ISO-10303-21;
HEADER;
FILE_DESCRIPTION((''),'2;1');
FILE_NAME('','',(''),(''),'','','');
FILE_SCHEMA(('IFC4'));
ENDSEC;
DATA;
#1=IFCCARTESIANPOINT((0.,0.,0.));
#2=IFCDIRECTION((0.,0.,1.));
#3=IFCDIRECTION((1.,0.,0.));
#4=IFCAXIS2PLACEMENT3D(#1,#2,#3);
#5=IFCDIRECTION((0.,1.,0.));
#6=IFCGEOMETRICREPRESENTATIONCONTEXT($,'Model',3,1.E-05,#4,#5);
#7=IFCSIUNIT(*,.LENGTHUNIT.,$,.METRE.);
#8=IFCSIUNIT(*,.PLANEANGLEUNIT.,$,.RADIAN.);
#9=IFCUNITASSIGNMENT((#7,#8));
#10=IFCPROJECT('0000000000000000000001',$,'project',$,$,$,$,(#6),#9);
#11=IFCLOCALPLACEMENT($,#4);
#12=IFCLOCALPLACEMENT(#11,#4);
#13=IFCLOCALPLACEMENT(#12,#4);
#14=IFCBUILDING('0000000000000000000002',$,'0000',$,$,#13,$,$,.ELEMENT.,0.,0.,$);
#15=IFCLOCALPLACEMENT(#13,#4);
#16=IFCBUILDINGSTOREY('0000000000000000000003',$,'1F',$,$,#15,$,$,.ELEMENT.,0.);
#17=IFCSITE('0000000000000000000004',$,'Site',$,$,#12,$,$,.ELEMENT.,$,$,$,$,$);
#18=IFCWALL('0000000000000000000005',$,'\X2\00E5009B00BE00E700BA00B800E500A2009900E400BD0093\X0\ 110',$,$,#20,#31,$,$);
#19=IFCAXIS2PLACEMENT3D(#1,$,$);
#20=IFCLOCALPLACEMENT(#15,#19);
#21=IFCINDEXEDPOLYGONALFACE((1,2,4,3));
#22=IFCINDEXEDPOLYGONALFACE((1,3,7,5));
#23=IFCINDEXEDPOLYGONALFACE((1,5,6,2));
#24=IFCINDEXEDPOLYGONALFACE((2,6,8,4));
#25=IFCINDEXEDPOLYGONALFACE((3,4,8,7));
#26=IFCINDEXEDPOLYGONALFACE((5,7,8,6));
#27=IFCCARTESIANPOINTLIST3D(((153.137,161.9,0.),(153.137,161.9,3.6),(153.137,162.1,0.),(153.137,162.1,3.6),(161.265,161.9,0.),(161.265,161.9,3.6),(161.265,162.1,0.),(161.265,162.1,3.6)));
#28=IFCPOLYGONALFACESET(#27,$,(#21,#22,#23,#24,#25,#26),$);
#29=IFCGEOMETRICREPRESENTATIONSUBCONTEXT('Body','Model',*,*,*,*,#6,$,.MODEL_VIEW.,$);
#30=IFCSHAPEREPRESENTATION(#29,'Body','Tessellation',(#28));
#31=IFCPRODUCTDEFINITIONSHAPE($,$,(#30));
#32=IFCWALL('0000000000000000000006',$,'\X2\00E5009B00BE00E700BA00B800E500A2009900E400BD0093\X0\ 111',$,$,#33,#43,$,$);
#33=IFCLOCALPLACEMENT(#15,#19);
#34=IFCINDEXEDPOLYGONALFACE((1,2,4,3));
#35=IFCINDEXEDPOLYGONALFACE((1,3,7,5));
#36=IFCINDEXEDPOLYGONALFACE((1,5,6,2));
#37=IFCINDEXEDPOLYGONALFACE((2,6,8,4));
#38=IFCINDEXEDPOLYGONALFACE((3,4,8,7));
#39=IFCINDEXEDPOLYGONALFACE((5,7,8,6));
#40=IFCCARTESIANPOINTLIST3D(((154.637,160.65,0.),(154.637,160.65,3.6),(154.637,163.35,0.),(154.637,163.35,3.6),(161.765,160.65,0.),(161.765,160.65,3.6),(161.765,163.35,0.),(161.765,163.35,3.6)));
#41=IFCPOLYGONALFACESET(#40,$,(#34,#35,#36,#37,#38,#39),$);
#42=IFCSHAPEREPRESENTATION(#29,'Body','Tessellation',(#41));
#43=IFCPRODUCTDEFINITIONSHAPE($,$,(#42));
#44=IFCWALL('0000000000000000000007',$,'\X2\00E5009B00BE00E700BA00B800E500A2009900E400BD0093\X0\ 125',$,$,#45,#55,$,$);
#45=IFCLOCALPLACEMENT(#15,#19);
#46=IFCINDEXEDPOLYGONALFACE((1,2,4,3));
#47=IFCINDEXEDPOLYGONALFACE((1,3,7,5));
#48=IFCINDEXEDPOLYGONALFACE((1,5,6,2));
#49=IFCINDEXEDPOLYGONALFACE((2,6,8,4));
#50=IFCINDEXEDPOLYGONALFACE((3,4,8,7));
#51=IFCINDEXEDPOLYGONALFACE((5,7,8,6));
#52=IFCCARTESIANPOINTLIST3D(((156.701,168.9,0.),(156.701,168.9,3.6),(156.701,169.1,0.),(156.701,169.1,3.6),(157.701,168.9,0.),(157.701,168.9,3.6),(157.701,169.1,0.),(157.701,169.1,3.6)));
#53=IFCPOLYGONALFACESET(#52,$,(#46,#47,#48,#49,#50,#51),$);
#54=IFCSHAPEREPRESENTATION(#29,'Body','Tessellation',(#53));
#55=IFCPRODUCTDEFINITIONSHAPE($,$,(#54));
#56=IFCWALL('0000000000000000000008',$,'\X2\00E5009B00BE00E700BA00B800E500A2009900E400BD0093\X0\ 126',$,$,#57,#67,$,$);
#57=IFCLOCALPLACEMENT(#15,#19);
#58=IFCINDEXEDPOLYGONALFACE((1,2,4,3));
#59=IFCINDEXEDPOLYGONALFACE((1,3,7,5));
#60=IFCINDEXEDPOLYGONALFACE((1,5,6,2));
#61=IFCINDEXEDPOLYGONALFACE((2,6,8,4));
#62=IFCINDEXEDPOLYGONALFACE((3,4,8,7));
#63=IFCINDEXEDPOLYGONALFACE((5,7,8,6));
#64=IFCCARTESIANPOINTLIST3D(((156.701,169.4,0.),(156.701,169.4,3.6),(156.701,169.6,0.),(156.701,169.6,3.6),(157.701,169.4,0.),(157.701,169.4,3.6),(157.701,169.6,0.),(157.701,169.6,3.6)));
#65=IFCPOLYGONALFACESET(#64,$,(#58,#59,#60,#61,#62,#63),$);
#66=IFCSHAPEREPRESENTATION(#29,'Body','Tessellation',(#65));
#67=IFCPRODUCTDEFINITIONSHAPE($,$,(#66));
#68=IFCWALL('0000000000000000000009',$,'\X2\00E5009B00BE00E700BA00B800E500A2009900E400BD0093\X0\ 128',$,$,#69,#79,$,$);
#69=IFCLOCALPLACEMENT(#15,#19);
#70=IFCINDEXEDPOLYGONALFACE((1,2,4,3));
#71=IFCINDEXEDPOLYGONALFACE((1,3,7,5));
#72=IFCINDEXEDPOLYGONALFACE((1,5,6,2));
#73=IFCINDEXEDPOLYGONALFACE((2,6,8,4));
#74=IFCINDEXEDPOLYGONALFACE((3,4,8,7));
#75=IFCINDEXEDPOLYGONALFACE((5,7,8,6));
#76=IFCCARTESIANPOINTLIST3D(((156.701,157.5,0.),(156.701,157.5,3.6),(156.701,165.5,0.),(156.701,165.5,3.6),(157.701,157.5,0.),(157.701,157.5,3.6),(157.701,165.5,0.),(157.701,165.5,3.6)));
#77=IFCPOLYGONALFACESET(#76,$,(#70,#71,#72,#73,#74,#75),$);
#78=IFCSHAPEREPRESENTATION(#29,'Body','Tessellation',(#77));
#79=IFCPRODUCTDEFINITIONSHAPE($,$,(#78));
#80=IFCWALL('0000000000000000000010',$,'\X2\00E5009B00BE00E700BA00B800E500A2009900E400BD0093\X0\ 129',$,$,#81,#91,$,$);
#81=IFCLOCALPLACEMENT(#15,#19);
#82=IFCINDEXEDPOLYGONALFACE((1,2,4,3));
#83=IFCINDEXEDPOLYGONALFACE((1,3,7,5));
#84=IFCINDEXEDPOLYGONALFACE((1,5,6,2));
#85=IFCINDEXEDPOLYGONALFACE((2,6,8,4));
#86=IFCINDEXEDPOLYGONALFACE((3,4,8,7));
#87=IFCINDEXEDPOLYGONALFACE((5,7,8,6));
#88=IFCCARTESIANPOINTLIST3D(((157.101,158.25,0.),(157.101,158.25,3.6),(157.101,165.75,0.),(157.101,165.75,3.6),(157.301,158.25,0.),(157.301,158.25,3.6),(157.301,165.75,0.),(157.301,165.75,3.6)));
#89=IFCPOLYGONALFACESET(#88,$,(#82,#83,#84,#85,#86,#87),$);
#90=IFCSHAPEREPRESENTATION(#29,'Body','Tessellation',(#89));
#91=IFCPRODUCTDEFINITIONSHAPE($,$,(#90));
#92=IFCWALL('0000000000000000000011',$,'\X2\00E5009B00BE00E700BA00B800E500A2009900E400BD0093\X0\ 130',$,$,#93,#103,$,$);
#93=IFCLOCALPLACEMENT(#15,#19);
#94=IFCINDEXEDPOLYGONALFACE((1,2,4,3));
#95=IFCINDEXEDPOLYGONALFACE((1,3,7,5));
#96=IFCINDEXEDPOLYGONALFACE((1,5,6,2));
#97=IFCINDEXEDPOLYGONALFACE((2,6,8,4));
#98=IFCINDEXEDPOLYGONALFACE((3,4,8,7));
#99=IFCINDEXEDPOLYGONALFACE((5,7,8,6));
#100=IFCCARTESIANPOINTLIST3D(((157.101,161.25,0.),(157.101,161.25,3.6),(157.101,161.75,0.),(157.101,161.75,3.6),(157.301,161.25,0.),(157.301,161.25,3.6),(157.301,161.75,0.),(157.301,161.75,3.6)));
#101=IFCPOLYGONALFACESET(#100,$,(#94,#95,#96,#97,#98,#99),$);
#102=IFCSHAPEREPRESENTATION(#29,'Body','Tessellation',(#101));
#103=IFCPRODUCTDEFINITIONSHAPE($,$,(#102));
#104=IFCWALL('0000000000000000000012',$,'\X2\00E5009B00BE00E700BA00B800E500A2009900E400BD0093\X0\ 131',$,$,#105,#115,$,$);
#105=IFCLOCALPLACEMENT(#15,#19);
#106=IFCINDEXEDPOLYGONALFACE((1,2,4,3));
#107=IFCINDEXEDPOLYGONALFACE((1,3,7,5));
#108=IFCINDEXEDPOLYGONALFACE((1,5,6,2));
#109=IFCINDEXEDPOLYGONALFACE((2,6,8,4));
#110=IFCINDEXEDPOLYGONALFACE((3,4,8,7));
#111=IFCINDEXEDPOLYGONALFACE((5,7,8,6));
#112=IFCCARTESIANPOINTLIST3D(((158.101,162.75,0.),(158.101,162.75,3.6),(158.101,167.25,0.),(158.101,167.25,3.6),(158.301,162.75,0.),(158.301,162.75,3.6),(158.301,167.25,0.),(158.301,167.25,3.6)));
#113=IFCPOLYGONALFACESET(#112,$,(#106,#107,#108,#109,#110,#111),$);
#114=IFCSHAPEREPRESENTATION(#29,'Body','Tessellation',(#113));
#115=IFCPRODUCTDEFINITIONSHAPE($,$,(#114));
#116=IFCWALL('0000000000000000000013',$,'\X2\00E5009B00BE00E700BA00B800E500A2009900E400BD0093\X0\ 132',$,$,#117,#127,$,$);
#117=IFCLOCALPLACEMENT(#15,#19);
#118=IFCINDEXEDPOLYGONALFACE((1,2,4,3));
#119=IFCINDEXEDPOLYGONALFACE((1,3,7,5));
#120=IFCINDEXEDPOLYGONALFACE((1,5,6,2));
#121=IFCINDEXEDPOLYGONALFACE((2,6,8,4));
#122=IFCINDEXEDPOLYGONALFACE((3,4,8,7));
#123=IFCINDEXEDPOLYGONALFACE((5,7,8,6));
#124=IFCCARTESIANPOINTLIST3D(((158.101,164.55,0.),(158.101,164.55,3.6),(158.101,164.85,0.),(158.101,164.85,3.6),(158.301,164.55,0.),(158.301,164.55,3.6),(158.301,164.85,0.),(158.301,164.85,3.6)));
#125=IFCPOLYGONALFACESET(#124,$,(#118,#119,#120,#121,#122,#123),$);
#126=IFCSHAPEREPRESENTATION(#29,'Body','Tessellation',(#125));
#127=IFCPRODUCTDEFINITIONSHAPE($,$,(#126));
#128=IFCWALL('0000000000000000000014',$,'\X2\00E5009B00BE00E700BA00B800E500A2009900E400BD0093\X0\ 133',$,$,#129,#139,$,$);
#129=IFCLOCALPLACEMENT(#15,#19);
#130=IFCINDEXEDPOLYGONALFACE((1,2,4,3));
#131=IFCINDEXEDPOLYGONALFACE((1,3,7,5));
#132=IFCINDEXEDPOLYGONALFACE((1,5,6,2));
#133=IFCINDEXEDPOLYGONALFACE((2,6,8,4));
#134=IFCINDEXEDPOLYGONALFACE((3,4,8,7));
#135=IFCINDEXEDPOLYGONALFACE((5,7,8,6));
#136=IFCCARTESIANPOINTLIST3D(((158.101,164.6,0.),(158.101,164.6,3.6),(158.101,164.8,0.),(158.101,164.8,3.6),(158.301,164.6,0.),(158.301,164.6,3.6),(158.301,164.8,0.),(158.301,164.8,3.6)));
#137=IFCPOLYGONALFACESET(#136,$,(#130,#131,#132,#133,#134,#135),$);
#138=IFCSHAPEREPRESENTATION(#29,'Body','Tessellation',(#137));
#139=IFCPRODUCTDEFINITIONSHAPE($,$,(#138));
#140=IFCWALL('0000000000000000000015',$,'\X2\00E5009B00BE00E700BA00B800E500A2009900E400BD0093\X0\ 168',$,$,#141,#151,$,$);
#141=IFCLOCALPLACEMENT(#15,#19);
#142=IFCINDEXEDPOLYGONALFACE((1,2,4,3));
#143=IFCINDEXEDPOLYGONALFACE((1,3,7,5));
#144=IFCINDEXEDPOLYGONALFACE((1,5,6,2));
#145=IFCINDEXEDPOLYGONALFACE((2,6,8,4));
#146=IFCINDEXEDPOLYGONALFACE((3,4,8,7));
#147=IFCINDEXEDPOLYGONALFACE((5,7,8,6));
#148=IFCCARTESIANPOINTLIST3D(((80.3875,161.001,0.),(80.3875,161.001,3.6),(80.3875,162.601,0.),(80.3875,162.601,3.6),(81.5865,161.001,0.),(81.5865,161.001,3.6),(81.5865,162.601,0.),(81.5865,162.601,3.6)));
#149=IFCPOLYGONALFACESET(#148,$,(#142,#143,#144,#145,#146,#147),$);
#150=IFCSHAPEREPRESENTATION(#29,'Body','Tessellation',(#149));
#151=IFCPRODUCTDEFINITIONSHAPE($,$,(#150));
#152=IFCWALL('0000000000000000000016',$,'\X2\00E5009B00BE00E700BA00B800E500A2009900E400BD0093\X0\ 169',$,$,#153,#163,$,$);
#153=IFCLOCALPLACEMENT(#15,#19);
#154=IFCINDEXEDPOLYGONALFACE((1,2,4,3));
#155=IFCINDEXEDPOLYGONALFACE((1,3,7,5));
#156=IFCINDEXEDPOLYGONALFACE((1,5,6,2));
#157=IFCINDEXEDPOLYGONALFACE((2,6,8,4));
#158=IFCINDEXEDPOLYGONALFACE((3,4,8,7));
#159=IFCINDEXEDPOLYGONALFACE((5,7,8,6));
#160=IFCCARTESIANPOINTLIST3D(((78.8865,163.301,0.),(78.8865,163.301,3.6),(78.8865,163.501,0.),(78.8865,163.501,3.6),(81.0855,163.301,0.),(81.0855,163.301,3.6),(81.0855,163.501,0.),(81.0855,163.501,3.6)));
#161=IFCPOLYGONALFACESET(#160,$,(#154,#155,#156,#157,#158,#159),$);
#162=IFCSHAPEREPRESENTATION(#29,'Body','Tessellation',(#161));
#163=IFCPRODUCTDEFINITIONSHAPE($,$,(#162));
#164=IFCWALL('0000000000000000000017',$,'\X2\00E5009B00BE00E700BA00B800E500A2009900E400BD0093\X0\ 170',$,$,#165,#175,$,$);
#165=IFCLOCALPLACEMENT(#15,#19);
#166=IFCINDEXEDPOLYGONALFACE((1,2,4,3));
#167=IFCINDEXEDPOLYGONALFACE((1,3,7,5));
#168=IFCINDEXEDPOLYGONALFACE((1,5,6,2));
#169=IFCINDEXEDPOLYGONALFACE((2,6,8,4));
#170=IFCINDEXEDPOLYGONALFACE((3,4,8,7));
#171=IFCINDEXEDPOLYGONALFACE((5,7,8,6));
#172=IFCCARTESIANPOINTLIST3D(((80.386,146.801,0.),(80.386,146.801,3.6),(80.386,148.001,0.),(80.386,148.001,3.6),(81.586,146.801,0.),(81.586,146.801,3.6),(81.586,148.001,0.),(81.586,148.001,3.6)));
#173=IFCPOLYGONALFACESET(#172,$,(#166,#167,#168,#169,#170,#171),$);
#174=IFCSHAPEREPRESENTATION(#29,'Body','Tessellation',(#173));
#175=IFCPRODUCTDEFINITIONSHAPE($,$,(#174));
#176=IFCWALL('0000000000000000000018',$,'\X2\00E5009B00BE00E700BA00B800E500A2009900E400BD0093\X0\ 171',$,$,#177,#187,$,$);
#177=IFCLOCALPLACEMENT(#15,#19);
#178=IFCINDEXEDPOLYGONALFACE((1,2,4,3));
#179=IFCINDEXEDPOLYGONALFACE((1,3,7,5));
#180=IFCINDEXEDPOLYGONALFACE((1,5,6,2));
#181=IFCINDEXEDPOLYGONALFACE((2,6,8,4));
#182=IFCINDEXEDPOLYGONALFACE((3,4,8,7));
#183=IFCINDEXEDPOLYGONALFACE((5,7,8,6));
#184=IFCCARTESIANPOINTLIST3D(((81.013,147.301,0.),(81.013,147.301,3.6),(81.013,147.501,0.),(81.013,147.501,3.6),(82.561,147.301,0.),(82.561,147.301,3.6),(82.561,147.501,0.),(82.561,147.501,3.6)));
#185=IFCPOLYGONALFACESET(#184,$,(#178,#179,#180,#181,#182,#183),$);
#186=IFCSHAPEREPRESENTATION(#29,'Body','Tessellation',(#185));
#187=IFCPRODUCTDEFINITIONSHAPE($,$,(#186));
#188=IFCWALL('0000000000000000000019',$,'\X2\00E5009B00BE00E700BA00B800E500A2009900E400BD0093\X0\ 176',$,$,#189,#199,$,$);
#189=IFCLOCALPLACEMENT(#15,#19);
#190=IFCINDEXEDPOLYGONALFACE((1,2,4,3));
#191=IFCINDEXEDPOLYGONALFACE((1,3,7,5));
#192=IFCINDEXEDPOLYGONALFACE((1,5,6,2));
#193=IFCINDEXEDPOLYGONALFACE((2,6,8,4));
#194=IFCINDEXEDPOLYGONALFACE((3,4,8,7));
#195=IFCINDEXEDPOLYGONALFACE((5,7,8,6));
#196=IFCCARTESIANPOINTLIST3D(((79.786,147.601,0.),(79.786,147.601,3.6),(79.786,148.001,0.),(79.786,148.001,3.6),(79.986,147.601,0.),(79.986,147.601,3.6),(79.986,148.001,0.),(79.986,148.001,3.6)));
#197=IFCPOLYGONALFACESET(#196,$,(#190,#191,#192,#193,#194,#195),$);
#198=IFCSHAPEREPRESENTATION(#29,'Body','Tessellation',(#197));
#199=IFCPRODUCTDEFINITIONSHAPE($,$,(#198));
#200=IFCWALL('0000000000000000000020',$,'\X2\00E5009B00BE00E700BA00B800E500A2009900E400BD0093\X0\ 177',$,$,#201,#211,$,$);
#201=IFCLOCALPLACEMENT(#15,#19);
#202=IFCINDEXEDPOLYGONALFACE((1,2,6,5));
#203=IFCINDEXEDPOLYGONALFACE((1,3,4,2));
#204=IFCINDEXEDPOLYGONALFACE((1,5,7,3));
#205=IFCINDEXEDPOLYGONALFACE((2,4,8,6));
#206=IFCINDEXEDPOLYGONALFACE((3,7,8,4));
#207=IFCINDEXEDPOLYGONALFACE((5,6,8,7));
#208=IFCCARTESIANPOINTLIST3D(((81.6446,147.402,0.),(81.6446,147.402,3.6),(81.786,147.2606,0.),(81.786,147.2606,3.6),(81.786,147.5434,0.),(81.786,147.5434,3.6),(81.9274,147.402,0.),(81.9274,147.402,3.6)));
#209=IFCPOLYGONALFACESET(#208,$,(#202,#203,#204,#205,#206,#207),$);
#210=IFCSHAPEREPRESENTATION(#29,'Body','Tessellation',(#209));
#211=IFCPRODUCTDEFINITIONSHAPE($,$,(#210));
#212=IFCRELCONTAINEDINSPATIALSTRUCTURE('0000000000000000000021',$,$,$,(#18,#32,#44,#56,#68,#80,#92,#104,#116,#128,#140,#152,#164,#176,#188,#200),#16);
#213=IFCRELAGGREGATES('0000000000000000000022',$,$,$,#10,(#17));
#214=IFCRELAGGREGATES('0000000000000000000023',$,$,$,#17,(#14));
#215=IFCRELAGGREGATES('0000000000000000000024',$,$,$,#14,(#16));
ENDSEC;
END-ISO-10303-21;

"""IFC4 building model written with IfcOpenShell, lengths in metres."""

from ifc_helpers import new_model, si_unit, direction, frame, frame_2d, origin_with_axes, place, context, subcontext, project, spatial, rectangle, extrude, element, save


model = new_model("IFC4")

# Units and contexts
model_context = context("Model", 3, precision=1e-05, world=origin_with_axes(), true_north=direction((0.0, 1.0, 0.0)))
body_context = subcontext(model_context, "Body", "Model", "MODEL_VIEW")
ifc_project = project(units=[si_unit("LENGTHUNIT", "METRE"), si_unit("PLANEANGLEUNIT", "RADIAN")], contexts=[model_context])

# Site, building, storey
placement = place(None, origin_with_axes())
site_placement = place(placement, origin_with_axes())
site = spatial("IfcSite", under=ifc_project, at=site_placement, Name="Site", CompositionType="ELEMENT")
building_placement = place(site_placement, origin_with_axes())
building = spatial("IfcBuilding", under=site, at=building_placement, Name="0000", CompositionType="ELEMENT", ElevationOfRefHeight=0.0, ElevationOfTerrain=0.0)
storey_placement = place(building_placement, origin_with_axes())
storey = spatial("IfcBuildingStorey", under=building, at=storey_placement, Name="1F", CompositionType="ELEMENT", Elevation=0.0)

# Walls
wall_1_placement = place(storey_placement, frame((157.201, 162.0, 0.0), z_axis=(0.0, 0.0, 1.0), x_axis=(1.0, 0.0, 0.0)))
element("IfcWall", 1, at=wall_1_placement, inside=storey, Name="å\u009b¾çº¸å¢\u0099ä½\u0093 110", context=body_context, shape_type="SweptSolid", body=[
    extrude(rectangle(XDim=8.128, YDim=0.2, at=frame_2d((0.0, 0.0), x_axis=(1.0, 0.0, 0.0))), frame((0.0, 0.0, 0.0), z_axis=(0.0, 0.0, 1.0)), (0.0, 0.0, 1.0), 3.6),
])
wall_2_placement = place(storey_placement, frame((158.201, 162.0, 0.0), z_axis=(0.0, 0.0, 1.0), x_axis=(1.0, 0.0, 0.0)))
element("IfcWall", 2, at=wall_2_placement, inside=storey, Name="å\u009b¾çº¸å¢\u0099ä½\u0093 111", context=body_context, shape_type="SweptSolid", body=[
    extrude(rectangle(XDim=7.128, YDim=2.7, at=frame_2d((0.0, 0.0), x_axis=(1.0, 0.0, 0.0))), frame((0.0, 0.0, 0.0), z_axis=(0.0, 0.0, 1.0)), (0.0, 0.0, 1.0), 3.6),
])
for number, where, z_axis, x_axis, name in (
    (3, (157.201, 169.0, 0.0), (0.0, 0.0, 1.0), (1.0, 0.0, 0.0), "å\u009b¾çº¸å¢\u0099ä½\u0093 125"),
    (4, (157.201, 169.5, 0.0), (0.0, 0.0, 1.0), (1.0, 0.0, 0.0), "å\u009b¾çº¸å¢\u0099ä½\u0093 126"),
):
    element("IfcWall", number, at=place(storey_placement, frame(where, z_axis=z_axis, x_axis=x_axis)), inside=storey, Name=name, context=body_context, shape_type="SweptSolid", body=[
        extrude(rectangle(XDim=1.0, YDim=0.2, at=frame_2d((0.0, 0.0), x_axis=(1.0, 0.0, 0.0))), frame((0.0, 0.0, 0.0), z_axis=(0.0, 0.0, 1.0)), (0.0, 0.0, 1.0), 3.6),
    ])
wall_3_placement = place(storey_placement, frame((157.201, 161.5, 0.0), z_axis=(0.0, 0.0, 1.0), x_axis=(1.0, 0.0, 0.0)))
element("IfcWall", 5, at=wall_3_placement, inside=storey, Name="å\u009b¾çº¸å¢\u0099ä½\u0093 128", context=body_context, shape_type="SweptSolid", body=[
    extrude(rectangle(XDim=1.0, YDim=8.0, at=frame_2d((0.0, 0.0), x_axis=(1.0, 0.0, 0.0))), frame((0.0, 0.0, 0.0), z_axis=(0.0, 0.0, 1.0)), (0.0, 0.0, 1.0), 3.6),
])
wall_4_placement = place(storey_placement, frame((157.201, 162.0, 0.0), z_axis=(0.0, 0.0, 1.0), x_axis=(0.0, 1.0, 0.0)))
element("IfcWall", 6, at=wall_4_placement, inside=storey, Name="å\u009b¾çº¸å¢\u0099ä½\u0093 129", context=body_context, shape_type="SweptSolid", body=[
    extrude(rectangle(XDim=7.5, YDim=0.2, at=frame_2d((0.0, 0.0), x_axis=(1.0, 0.0, 0.0))), frame((0.0, 0.0, 0.0), z_axis=(0.0, 0.0, 1.0)), (0.0, 0.0, 1.0), 3.6),
])
wall_5_placement = place(storey_placement, frame((157.201, 161.5, 0.0), z_axis=(0.0, 0.0, 1.0), x_axis=(0.0, 1.0, 0.0)))
element("IfcWall", 7, at=wall_5_placement, inside=storey, Name="å\u009b¾çº¸å¢\u0099ä½\u0093 130", context=body_context, shape_type="SweptSolid", body=[
    extrude(rectangle(XDim=0.5, YDim=0.2, at=frame_2d((0.0, 0.0), x_axis=(1.0, 0.0, 0.0))), frame((0.0, 0.0, 0.0), z_axis=(0.0, 0.0, 1.0)), (0.0, 0.0, 1.0), 3.6),
])
wall_6_placement = place(storey_placement, frame((158.201, 165.0, 0.0), z_axis=(0.0, 0.0, 1.0), x_axis=(0.0, 1.0, 0.0)))
element("IfcWall", 8, at=wall_6_placement, inside=storey, Name="å\u009b¾çº¸å¢\u0099ä½\u0093 131", context=body_context, shape_type="SweptSolid", body=[
    extrude(rectangle(XDim=4.5, YDim=0.2, at=frame_2d((0.0, 0.0), x_axis=(1.0, 0.0, 0.0))), frame((0.0, 0.0, 0.0), z_axis=(0.0, 0.0, 1.0)), (0.0, 0.0, 1.0), 3.6),
])
wall_7_placement = place(storey_placement, frame((158.201, 164.7, 0.0), z_axis=(0.0, 0.0, 1.0), x_axis=(1.0, 0.0, 0.0)))
element("IfcWall", 9, at=wall_7_placement, inside=storey, Name="å\u009b¾çº¸å¢\u0099ä½\u0093 132", context=body_context, shape_type="SweptSolid", body=[
    extrude(rectangle(XDim=0.2, YDim=0.3, at=frame_2d((0.0, 0.0), x_axis=(1.0, 0.0, 0.0))), frame((0.0, 0.0, 0.0), z_axis=(0.0, 0.0, 1.0)), (0.0, 0.0, 1.0), 3.6),
])
wall_8_placement = place(storey_placement, frame((158.201, 164.7, 0.0), z_axis=(0.0, 0.0, 1.0), x_axis=(1.0, 0.0, 0.0)))
element("IfcWall", 10, at=wall_8_placement, inside=storey, Name="å\u009b¾çº¸å¢\u0099ä½\u0093 133", context=body_context, shape_type="SweptSolid", body=[
    extrude(rectangle(XDim=0.2, YDim=0.2, at=frame_2d((0.0, 0.0), x_axis=(1.0, 0.0, 0.0))), frame((0.0, 0.0, 0.0), z_axis=(0.0, 0.0, 1.0)), (0.0, 0.0, 1.0), 3.6),
])
wall_9_placement = place(storey_placement, frame((80.987, 161.801, 0.0), z_axis=(0.0, 0.0, 1.0), x_axis=(1.0, 0.0, 0.0)))
element("IfcWall", 11, at=wall_9_placement, inside=storey, Name="å\u009b¾çº¸å¢\u0099ä½\u0093 168", context=body_context, shape_type="SweptSolid", body=[
    extrude(rectangle(XDim=1.199, YDim=1.6, at=frame_2d((0.0, 0.0), x_axis=(1.0, 0.0, 0.0))), frame((0.0, 0.0, 0.0), z_axis=(0.0, 0.0, 1.0)), (0.0, 0.0, 1.0), 3.6),
])
wall_10_placement = place(storey_placement, frame((79.986, 163.401, 0.0), z_axis=(0.0, 0.0, 1.0), x_axis=(1.0, 0.0, 0.0)))
element("IfcWall", 12, at=wall_10_placement, inside=storey, Name="å\u009b¾çº¸å¢\u0099ä½\u0093 169", context=body_context, shape_type="SweptSolid", body=[
    extrude(rectangle(XDim=2.199, YDim=0.2, at=frame_2d((0.0, 0.0), x_axis=(1.0, 0.0, 0.0))), frame((0.0, 0.0, 0.0), z_axis=(0.0, 0.0, 1.0)), (0.0, 0.0, 1.0), 3.6),
])
wall_11_placement = place(storey_placement, frame((80.986, 147.401, 0.0), z_axis=(0.0, 0.0, 1.0), x_axis=(1.0, 0.0, 0.0)))
element("IfcWall", 13, at=wall_11_placement, inside=storey, Name="å\u009b¾çº¸å¢\u0099ä½\u0093 170", context=body_context, shape_type="SweptSolid", body=[
    extrude(rectangle(XDim=1.2, YDim=1.2, at=frame_2d((0.0, 0.0), x_axis=(1.0, 0.0, 0.0))), frame((0.0, 0.0, 0.0), z_axis=(0.0, 0.0, 1.0)), (0.0, 0.0, 1.0), 3.6),
])
wall_12_placement = place(storey_placement, frame((81.787, 147.401, 0.0), z_axis=(0.0, 0.0, 1.0), x_axis=(1.0, 0.0, 0.0)))
element("IfcWall", 14, at=wall_12_placement, inside=storey, Name="å\u009b¾çº¸å¢\u0099ä½\u0093 171", context=body_context, shape_type="SweptSolid", body=[
    extrude(rectangle(XDim=1.548, YDim=0.2, at=frame_2d((0.0, 0.0), x_axis=(1.0, 0.0, 0.0))), frame((0.0, 0.0, 0.0), z_axis=(0.0, 0.0, 1.0)), (0.0, 0.0, 1.0), 3.6),
])
wall_13_placement = place(storey_placement, frame((79.886, 147.801, 0.0), z_axis=(0.0, 0.0, 1.0), x_axis=(0.0, -1.0, 0.0)))
element("IfcWall", 15, at=wall_13_placement, inside=storey, Name="å\u009b¾çº¸å¢\u0099ä½\u0093 176", context=body_context, shape_type="SweptSolid", body=[
    extrude(rectangle(XDim=0.4, YDim=0.2, at=frame_2d((0.0, 0.0), x_axis=(1.0, 0.0, 0.0))), frame((0.0, 0.0, 0.0), z_axis=(0.0, 0.0, 1.0)), (0.0, 0.0, 1.0), 3.6),
])
wall_14_placement = place(storey_placement, frame((81.786, 147.402, 0.0), z_axis=(0.0, 0.0, 1.0), x_axis=(0.707107, -0.707107, 0.0)))
element("IfcWall", 16, at=wall_14_placement, inside=storey, Name="å\u009b¾çº¸å¢\u0099ä½\u0093 177", context=body_context, shape_type="SweptSolid", body=[
    extrude(rectangle(XDim=0.2, YDim=0.2, at=frame_2d((0.0, 0.0), x_axis=(1.0, 0.0, 0.0))), frame((0.0, 0.0, 0.0), z_axis=(0.0, 0.0, 1.0)), (0.0, 0.0, 1.0), 3.6),
])

save(model, "model.ifc")
